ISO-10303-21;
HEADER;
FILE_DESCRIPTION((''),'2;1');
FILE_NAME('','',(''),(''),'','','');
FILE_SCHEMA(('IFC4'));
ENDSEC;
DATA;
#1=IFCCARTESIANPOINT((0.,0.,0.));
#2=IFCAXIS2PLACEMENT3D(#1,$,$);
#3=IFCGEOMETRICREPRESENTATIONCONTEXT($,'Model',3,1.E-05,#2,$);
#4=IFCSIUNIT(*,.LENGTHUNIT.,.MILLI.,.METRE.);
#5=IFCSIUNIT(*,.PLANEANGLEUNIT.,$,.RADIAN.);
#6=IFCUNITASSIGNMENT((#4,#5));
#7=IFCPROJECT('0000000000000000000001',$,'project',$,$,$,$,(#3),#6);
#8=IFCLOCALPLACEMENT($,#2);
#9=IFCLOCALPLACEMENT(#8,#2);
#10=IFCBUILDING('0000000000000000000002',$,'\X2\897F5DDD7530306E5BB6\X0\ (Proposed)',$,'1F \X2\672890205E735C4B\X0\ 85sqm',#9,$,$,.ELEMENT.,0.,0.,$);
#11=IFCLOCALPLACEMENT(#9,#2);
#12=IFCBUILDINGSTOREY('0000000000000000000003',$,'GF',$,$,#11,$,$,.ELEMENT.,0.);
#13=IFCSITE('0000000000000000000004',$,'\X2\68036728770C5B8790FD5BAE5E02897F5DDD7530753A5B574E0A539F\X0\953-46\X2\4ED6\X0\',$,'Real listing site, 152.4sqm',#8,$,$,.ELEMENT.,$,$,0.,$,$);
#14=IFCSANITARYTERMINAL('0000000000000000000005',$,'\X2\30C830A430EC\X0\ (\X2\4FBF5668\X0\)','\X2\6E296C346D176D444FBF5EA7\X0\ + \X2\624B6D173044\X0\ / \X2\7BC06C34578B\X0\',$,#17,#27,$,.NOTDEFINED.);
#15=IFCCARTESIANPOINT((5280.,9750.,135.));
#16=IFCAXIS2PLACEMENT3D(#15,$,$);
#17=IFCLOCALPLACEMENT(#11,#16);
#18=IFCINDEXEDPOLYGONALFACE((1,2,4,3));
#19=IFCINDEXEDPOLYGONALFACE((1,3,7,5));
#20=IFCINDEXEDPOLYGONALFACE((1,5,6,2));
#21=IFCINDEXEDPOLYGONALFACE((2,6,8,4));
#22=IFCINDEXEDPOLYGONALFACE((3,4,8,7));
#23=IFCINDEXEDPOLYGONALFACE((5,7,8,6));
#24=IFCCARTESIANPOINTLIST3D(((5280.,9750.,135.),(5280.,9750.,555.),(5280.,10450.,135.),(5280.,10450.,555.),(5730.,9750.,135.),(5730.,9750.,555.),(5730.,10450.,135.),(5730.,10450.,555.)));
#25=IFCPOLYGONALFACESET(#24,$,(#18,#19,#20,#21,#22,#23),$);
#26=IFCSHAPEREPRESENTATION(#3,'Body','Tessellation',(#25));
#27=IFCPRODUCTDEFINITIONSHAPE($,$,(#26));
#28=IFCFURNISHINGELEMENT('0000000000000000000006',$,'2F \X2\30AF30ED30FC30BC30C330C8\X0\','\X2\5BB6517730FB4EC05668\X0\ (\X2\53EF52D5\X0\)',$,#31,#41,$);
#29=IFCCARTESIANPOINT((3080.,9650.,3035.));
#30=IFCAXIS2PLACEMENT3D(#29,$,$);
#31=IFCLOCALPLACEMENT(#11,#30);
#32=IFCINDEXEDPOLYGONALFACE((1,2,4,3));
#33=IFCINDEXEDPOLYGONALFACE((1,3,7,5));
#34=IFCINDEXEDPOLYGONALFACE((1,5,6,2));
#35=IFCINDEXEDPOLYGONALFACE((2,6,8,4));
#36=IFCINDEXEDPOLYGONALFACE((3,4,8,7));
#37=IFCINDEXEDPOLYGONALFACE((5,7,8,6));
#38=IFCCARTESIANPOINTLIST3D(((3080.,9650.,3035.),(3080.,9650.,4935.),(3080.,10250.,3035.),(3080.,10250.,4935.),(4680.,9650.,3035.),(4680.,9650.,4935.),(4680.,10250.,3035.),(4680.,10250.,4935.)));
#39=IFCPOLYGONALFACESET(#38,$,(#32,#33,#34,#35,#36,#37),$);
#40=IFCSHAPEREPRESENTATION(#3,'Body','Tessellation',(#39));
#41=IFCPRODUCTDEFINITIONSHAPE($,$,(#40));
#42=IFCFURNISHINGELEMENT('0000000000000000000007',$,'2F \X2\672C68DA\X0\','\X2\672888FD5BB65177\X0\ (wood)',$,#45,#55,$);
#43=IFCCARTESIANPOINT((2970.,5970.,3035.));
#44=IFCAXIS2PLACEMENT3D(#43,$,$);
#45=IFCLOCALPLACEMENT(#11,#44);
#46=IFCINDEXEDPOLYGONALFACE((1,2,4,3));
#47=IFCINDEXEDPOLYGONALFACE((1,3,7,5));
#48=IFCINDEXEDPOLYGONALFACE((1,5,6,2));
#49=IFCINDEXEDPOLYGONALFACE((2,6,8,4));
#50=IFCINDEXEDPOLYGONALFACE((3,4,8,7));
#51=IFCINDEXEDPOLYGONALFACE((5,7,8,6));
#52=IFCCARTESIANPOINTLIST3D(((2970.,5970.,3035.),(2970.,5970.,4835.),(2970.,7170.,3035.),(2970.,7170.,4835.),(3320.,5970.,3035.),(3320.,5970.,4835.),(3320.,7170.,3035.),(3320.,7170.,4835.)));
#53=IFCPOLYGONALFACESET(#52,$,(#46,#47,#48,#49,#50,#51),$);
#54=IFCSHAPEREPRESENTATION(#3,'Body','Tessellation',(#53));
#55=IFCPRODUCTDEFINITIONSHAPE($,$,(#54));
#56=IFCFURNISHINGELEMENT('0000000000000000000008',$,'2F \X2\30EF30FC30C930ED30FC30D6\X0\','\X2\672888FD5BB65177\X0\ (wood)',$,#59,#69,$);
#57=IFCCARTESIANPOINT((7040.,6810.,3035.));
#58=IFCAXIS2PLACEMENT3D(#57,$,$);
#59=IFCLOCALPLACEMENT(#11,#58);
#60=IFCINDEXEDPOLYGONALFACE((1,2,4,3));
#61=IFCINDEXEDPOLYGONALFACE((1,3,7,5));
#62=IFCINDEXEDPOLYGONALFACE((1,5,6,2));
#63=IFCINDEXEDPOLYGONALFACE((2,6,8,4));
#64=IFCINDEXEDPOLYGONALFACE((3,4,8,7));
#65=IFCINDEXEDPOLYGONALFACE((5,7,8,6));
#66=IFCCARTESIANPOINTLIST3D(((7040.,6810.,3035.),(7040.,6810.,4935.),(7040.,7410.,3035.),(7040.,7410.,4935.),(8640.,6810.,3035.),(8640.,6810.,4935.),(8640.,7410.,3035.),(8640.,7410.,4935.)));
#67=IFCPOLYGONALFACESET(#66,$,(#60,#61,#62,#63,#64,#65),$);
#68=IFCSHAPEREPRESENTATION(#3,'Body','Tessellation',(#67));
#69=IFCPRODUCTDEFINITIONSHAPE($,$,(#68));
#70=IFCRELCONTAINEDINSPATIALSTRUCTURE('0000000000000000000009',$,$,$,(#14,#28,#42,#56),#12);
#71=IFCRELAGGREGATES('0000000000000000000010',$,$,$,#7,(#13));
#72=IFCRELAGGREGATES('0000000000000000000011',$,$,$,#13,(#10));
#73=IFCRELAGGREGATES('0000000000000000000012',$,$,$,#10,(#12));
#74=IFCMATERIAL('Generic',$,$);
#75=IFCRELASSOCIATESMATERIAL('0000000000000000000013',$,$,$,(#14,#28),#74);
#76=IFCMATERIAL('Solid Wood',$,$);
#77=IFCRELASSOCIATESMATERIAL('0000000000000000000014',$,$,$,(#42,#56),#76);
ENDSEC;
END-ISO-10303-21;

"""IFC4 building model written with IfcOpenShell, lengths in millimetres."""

from ifc_helpers import new_model, si_unit, frame, frame_2d, origin, place, context, project, spatial, rectangle, extrude, material, element, save


model = new_model("IFC4")

# Units and contexts
model_context = context("Model", 3, precision=1e-05, world=origin())
ifc_project = project(units=[si_unit("LENGTHUNIT", "METRE", prefix="MILLI"), si_unit("PLANEANGLEUNIT", "RADIAN")], contexts=[model_context])

# Site, building, storey
site_placement = place(None, origin())
site = spatial("IfcSite", under=ifc_project, at=site_placement, Name="栃木県宇都宮市西川田町字上原953-46他", ObjectType="Real listing site, 152.4sqm", CompositionType="ELEMENT", RefElevation=0.0)
building_placement = place(site_placement, origin())
building = spatial("IfcBuilding", under=site, at=building_placement, Name="西川田の家 (Proposed)", ObjectType="1F 木造平屋 85sqm", CompositionType="ELEMENT", ElevationOfRefHeight=0.0, ElevationOfTerrain=0.0)
storey_placement = place(building_placement, origin())
storey = spatial("IfcBuildingStorey", under=building, at=storey_placement, Name="GF", CompositionType="ELEMENT", Elevation=0.0)

# Shared definitions
ifc_material_1 = material(Name="Solid Wood")

# Shared definitions
ifc_material_2 = material(Name="Generic")

# Sanitary terminal
sanitary_terminal_placement = place(storey_placement, frame((5280.0, 9750.0, 135.0)))
element("IfcSanitaryTerminal", 1, at=sanitary_terminal_placement, inside=storey, material=ifc_material_2, Name="トイレ (便器)", Description="温水洗浄便座 + 手洗い / 節水型", PredefinedType="NOTDEFINED", context=model_context, shape_type="SweptSolid", body=[
    extrude(rectangle(XDim=450.0, YDim=700.0, at=frame_2d((225.0, 350.0))), frame((5280.0, 9750.0, 135.0)), (0.0, 0.0, 1.0), 420.0),
])

# Furnishing elements
furnishing_1_placement = place(storey_placement, frame((3080.0, 9650.0, 3035.0)))
element("IfcFurnishingElement", 2, at=furnishing_1_placement, inside=storey, material=ifc_material_2, Name="2F クローゼット", Description="家具・什器 (可動)", context=model_context, shape_type="SweptSolid", body=[
    extrude(rectangle(XDim=1600.0, YDim=600.0, at=frame_2d((800.0, 300.0))), frame((3080.0, 9650.0, 3035.0)), (0.0, 0.0, 1.0), 1900.0),
])
furnishing_2_placement = place(storey_placement, frame((2970.0, 5970.0, 3035.0)))
element("IfcFurnishingElement", 3, at=furnishing_2_placement, inside=storey, material=ifc_material_1, Name="2F 本棚", Description="木製家具 (wood)", context=model_context, shape_type="SweptSolid", body=[
    extrude(rectangle(XDim=350.0, YDim=1200.0, at=frame_2d((175.0, 600.0))), frame((2970.0, 5970.0, 3035.0)), (0.0, 0.0, 1.0), 1800.0),
])
furnishing_3_placement = place(storey_placement, frame((7040.0, 6810.0, 3035.0)))
element("IfcFurnishingElement", 4, at=furnishing_3_placement, inside=storey, material=ifc_material_1, Name="2F ワードローブ", Description="木製家具 (wood)", context=model_context, shape_type="SweptSolid", body=[
    extrude(rectangle(XDim=1600.0, YDim=600.0, at=frame_2d((800.0, 300.0))), frame((7040.0, 6810.0, 3035.0)), (0.0, 0.0, 1.0), 1900.0),
])

save(model, "model.ifc")
